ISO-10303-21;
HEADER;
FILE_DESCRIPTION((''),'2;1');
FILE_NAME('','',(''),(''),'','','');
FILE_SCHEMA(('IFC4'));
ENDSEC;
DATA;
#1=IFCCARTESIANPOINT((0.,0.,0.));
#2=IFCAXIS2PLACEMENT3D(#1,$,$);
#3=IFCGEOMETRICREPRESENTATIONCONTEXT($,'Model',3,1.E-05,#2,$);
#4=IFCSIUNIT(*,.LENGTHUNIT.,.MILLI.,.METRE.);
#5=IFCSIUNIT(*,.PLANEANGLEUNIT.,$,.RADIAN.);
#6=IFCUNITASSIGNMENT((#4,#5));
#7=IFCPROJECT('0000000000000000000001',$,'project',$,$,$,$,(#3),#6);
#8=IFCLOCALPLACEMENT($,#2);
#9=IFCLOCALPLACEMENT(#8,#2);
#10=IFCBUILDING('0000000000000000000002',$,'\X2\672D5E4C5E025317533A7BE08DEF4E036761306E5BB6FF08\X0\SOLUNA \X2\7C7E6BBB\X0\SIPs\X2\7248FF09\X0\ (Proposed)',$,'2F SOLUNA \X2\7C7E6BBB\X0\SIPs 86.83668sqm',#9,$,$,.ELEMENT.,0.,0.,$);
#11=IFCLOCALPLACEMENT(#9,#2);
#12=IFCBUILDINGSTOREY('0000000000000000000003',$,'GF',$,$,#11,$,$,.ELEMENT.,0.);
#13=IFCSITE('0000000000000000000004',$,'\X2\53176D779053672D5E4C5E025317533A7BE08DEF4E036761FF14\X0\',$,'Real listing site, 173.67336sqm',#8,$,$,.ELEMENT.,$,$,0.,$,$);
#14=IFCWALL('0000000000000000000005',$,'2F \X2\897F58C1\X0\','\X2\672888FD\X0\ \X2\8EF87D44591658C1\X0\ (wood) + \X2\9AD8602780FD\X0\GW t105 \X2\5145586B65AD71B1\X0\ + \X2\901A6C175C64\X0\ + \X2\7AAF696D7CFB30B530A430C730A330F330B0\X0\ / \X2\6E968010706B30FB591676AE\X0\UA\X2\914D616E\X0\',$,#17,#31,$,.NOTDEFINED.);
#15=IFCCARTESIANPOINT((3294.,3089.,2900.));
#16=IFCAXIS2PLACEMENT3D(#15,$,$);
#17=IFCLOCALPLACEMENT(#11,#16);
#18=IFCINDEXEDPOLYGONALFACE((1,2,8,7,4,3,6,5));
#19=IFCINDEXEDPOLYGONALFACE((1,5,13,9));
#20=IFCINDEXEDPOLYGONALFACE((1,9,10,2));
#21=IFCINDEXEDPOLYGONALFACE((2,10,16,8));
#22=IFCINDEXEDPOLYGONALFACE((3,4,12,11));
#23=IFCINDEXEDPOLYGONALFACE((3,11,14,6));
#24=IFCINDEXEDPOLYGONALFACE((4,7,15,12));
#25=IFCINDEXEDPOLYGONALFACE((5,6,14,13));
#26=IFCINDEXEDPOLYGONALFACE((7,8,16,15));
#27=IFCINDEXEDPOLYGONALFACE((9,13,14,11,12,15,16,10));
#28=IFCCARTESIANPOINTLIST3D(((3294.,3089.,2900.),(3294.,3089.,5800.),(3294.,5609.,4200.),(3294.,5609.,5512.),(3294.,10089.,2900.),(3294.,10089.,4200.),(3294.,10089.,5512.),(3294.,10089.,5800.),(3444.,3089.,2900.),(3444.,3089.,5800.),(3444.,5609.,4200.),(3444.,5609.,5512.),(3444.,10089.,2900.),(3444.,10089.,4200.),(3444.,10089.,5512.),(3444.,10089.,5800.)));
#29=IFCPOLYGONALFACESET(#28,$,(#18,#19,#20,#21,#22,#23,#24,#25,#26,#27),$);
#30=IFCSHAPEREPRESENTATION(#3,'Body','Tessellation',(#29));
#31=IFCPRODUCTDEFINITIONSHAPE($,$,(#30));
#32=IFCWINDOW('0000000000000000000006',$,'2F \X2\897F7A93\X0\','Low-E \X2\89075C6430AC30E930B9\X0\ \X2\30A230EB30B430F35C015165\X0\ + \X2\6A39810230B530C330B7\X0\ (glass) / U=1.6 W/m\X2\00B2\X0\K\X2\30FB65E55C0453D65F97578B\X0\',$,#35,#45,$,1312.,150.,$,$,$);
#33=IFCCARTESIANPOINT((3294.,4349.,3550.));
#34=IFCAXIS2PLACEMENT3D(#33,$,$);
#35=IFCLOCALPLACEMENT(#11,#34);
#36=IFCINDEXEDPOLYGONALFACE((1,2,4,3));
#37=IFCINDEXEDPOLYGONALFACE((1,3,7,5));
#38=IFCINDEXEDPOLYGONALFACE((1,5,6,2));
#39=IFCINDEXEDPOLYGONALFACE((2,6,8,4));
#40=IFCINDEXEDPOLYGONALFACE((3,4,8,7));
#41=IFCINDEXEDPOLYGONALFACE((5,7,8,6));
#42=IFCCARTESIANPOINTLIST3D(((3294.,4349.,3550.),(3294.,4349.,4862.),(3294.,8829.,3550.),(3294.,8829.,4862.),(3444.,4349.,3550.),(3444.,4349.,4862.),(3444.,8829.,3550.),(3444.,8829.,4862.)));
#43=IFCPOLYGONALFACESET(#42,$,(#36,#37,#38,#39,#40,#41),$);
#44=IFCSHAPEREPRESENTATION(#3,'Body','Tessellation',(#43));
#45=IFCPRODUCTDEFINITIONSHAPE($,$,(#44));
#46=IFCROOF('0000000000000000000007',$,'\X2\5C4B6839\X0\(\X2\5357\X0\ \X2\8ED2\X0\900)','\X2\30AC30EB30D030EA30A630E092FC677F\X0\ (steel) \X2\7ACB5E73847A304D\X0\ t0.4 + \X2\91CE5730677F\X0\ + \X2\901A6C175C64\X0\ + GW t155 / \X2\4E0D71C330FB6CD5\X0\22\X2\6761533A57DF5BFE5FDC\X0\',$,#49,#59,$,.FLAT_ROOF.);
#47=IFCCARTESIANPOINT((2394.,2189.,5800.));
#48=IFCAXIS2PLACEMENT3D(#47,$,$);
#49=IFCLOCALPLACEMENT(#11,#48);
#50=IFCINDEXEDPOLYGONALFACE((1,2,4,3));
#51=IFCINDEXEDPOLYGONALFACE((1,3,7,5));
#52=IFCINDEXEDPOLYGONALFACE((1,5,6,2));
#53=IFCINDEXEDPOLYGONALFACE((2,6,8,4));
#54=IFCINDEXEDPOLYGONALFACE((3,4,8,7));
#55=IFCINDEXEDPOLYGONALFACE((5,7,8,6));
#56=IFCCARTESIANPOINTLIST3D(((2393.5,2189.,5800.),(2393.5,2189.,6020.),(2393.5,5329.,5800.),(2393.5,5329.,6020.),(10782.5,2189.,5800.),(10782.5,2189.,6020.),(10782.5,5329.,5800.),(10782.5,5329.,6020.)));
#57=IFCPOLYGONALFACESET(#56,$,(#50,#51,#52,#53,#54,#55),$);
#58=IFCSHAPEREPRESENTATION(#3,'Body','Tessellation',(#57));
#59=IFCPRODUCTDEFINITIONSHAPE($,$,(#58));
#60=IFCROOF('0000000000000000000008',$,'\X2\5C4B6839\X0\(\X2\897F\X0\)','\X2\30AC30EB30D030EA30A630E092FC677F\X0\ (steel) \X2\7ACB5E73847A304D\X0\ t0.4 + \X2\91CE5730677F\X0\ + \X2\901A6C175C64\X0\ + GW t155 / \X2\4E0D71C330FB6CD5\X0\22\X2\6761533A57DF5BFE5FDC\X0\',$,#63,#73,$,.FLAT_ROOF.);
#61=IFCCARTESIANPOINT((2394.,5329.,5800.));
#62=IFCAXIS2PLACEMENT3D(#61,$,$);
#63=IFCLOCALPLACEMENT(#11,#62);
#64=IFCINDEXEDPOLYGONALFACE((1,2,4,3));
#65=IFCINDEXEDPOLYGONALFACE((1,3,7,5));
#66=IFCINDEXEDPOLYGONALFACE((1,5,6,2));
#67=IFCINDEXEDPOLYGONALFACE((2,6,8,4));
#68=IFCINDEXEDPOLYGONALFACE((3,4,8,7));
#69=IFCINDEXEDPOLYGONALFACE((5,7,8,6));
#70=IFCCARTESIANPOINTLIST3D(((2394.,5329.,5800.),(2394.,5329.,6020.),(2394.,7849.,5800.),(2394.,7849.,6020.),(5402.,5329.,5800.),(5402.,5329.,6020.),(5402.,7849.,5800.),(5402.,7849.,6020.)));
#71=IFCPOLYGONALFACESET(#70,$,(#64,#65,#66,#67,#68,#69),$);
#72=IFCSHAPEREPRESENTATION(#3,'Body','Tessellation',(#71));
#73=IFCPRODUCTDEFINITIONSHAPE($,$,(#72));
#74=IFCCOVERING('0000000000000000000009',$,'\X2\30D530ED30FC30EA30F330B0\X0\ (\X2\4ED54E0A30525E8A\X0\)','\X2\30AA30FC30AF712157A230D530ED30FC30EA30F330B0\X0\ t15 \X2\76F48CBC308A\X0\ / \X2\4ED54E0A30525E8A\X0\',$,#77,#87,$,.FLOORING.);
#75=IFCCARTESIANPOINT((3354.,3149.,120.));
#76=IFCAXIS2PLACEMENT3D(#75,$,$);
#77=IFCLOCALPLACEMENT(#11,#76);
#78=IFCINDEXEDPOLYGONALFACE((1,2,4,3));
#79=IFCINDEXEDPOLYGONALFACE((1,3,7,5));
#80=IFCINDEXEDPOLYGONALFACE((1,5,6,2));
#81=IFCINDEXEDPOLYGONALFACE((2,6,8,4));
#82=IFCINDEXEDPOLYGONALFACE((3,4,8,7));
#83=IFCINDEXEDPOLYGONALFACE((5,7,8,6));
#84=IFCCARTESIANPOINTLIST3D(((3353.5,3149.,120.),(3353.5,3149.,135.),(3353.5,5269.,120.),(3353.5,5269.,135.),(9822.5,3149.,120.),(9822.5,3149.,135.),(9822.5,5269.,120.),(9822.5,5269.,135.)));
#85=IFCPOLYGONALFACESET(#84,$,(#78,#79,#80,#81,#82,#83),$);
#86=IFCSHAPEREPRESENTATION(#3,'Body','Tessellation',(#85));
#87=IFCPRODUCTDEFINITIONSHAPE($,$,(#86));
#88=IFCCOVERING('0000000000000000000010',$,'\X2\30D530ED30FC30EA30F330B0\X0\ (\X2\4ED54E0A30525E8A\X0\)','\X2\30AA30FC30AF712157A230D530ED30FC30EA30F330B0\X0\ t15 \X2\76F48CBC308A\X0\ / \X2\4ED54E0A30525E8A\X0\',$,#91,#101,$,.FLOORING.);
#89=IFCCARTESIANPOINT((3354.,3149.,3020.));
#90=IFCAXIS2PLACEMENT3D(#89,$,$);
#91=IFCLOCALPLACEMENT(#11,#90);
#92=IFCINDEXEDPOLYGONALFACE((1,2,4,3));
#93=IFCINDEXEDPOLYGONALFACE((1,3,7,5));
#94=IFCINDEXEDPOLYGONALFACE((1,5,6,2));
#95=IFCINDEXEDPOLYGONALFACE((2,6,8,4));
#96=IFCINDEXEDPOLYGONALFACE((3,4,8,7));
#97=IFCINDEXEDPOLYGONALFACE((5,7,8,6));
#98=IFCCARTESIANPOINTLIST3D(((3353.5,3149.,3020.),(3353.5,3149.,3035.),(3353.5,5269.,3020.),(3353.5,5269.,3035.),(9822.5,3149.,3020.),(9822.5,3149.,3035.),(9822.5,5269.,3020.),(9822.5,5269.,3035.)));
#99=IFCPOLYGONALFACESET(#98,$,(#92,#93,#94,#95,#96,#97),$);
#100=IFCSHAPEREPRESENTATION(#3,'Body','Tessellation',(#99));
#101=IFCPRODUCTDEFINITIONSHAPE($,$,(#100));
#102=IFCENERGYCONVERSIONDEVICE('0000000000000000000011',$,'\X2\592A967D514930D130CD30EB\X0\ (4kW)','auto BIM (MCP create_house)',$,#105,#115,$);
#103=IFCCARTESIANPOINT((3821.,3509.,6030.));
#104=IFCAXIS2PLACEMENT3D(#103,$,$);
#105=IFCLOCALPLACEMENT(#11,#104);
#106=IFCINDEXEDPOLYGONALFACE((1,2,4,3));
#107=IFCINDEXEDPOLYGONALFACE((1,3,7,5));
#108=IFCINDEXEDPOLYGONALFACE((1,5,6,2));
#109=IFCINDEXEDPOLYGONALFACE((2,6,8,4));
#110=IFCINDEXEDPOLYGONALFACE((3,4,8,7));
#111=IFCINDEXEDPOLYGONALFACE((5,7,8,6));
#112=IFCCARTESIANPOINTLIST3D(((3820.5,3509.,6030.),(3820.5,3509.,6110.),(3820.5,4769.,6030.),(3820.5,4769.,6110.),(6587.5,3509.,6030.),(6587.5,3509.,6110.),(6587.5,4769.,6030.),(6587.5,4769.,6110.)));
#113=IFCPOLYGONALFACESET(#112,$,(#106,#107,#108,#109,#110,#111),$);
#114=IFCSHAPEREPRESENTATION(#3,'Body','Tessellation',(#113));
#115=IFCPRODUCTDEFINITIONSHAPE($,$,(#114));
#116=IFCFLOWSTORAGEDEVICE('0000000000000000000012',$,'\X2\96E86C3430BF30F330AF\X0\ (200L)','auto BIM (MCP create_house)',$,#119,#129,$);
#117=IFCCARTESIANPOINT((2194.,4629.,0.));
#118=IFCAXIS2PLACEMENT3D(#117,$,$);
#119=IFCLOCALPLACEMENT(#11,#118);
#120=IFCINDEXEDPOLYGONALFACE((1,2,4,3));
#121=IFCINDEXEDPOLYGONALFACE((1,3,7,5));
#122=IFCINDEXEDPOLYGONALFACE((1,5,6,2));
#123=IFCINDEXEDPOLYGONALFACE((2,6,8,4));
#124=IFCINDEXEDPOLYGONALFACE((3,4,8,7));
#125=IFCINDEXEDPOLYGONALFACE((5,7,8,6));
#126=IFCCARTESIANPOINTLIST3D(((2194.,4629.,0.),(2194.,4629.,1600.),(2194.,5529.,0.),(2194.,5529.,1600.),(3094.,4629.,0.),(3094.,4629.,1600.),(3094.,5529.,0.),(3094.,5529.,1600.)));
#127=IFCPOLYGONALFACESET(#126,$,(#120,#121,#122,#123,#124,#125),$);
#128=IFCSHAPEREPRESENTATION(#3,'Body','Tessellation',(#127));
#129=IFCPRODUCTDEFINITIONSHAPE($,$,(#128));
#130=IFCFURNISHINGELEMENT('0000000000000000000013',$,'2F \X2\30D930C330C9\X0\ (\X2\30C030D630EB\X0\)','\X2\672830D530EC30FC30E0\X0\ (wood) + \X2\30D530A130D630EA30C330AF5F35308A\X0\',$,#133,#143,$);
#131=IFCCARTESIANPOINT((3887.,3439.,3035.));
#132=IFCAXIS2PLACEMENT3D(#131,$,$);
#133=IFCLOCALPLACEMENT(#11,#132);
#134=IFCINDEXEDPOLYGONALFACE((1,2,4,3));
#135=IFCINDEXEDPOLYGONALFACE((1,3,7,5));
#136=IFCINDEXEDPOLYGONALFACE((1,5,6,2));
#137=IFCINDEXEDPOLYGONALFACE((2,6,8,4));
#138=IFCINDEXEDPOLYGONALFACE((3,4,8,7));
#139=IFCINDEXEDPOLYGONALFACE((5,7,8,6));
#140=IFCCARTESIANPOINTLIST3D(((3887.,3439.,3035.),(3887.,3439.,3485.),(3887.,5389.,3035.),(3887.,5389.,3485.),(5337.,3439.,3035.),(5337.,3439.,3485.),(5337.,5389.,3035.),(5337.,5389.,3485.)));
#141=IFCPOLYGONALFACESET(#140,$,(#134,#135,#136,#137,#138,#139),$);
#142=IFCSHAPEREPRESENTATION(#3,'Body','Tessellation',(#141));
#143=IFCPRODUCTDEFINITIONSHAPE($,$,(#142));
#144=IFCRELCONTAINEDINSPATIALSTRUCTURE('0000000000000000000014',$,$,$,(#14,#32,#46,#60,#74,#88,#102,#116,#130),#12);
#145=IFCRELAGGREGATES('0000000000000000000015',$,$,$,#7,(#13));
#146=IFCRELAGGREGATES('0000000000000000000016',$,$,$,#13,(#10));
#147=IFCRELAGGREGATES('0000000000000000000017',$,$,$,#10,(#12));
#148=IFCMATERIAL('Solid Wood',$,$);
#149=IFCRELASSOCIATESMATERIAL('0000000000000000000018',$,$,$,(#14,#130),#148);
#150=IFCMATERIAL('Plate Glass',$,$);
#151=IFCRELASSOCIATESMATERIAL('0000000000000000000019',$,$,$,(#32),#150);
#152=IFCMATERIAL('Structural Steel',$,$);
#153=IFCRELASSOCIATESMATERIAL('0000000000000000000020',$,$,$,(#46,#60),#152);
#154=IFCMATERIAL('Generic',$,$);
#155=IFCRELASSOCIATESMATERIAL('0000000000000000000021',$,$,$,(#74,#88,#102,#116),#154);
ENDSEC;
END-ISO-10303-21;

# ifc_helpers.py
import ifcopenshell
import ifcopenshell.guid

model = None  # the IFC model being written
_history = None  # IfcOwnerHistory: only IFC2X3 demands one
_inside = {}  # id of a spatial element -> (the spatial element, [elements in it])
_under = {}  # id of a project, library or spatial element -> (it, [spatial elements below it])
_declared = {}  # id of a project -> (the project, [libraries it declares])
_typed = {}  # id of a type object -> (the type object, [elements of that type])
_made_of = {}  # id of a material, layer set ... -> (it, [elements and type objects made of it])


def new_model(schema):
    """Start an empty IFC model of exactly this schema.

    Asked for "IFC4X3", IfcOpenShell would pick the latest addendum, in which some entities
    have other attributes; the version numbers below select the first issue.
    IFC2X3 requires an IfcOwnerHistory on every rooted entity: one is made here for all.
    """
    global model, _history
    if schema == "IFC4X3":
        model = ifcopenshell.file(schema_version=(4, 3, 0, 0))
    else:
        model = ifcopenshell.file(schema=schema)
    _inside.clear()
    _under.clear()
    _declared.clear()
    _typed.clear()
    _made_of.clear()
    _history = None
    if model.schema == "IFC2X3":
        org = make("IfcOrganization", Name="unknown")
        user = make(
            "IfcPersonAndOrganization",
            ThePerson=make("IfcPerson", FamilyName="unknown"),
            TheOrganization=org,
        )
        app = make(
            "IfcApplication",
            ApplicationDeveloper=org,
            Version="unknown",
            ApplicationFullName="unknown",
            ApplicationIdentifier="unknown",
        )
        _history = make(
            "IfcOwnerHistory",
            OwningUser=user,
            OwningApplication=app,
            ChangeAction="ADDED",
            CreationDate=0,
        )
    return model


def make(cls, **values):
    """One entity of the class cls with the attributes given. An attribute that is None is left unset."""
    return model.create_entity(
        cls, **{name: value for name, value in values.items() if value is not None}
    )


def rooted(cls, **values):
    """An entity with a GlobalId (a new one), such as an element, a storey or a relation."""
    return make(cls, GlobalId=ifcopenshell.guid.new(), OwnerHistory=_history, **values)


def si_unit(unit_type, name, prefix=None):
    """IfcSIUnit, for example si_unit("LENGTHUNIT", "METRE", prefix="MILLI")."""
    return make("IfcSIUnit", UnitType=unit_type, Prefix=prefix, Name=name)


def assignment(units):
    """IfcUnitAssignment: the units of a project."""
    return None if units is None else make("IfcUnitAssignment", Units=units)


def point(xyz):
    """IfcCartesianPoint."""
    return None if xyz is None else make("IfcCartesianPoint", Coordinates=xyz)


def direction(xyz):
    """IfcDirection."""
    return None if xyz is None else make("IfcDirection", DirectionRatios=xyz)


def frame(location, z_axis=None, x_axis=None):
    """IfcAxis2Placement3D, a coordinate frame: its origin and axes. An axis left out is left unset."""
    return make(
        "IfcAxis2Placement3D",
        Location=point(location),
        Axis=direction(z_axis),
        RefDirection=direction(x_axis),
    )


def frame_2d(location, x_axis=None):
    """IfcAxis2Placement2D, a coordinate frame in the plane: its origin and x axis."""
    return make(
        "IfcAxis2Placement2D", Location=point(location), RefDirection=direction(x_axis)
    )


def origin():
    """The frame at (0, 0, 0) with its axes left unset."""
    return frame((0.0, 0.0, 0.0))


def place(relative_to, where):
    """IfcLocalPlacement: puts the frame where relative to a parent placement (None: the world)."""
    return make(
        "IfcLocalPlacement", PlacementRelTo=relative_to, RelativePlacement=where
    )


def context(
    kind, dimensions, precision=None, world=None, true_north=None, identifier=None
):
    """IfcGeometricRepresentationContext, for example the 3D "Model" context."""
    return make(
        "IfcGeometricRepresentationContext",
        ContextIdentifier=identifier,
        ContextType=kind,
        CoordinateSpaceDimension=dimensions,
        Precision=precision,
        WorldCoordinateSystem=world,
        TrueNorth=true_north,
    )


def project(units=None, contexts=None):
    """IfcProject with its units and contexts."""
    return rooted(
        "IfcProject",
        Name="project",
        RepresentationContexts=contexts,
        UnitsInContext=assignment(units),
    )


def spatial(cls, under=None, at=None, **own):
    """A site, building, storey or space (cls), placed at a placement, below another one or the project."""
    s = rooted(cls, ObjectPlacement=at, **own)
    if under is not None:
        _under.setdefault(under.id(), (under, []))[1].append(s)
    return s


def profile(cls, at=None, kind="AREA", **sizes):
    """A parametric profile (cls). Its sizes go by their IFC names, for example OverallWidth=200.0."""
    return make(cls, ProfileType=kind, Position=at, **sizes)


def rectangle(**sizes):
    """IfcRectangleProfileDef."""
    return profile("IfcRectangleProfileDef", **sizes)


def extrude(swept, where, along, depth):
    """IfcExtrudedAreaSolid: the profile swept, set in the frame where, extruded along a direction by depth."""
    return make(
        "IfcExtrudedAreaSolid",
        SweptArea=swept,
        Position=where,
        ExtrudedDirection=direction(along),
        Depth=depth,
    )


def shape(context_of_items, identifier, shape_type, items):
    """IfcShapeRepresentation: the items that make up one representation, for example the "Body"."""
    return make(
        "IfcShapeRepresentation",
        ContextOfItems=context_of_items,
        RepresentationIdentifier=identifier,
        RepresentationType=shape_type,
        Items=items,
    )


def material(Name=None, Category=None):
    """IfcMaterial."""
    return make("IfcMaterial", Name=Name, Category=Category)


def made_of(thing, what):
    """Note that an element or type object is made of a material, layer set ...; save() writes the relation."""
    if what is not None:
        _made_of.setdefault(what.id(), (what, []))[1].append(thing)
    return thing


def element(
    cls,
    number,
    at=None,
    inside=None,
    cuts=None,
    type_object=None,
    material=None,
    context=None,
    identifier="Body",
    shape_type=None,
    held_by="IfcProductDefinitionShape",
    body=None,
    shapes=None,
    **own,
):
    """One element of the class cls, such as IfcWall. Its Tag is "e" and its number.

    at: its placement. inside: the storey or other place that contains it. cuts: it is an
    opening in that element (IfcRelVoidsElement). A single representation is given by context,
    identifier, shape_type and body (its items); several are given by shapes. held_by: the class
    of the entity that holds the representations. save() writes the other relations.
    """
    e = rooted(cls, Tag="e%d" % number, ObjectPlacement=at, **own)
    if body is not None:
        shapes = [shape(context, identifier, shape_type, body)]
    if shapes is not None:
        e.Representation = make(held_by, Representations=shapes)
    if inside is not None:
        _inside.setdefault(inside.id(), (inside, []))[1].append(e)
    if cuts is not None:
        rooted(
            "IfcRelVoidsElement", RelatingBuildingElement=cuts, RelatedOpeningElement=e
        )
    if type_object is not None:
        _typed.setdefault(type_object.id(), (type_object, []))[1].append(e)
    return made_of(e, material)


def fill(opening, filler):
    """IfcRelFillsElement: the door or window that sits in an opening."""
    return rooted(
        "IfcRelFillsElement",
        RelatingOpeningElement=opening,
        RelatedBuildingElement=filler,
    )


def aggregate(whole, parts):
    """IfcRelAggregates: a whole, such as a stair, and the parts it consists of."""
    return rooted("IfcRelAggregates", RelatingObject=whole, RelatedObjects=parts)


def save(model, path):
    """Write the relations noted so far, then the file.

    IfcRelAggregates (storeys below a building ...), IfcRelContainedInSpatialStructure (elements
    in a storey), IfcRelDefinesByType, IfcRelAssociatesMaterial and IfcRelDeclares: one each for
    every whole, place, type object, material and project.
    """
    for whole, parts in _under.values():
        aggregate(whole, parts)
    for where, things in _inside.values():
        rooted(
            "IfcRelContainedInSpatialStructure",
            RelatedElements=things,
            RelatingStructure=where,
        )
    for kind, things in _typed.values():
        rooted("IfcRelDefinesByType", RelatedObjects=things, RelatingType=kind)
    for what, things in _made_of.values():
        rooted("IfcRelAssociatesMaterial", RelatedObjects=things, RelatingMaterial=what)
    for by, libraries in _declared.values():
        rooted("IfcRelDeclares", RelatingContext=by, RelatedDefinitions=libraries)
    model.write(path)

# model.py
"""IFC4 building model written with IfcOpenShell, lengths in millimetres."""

from ifc_helpers import new_model, si_unit, frame, frame_2d, origin, place, context, project, spatial, rectangle, extrude, material, element, fill, save


model = new_model("IFC4")

# Units and contexts
model_context = context("Model", 3, precision=1e-05, world=origin())
ifc_project = project(units=[si_unit("LENGTHUNIT", "METRE", prefix="MILLI"), si_unit("PLANEANGLEUNIT", "RADIAN")], contexts=[model_context])

# Site, building, storey
site_placement = place(None, origin())
site = spatial("IfcSite", under=ifc_project, at=site_placement, Name="北海道札幌市北区篠路七条４", ObjectType="Real listing site, 173.67336sqm", CompositionType="ELEMENT", RefElevation=0.0)
building_placement = place(site_placement, origin())
building = spatial("IfcBuilding", under=site, at=building_placement, Name="札幌市北区篠路七条の家（SOLUNA 籾殻SIPs版） (Proposed)", ObjectType="2F SOLUNA 籾殻SIPs 86.83668sqm", CompositionType="ELEMENT", ElevationOfRefHeight=0.0, ElevationOfTerrain=0.0)
storey_placement = place(building_placement, origin())
storey = spatial("IfcBuildingStorey", under=building, at=storey_placement, Name="GF", CompositionType="ELEMENT", Elevation=0.0)

# Shared definitions
ifc_material_1 = material(Name="Solid Wood")

# Shared definitions
ifc_material_2 = material(Name="Plate Glass")

# Wall, opening, window
wall_1_placement = place(storey_placement, frame((3294.0, 3089.0, 2900.0)))
wall_1 = element("IfcWall", 1, at=wall_1_placement, inside=storey, material=ifc_material_1, Name="2F 西壁", Description="木製 軸組外壁 (wood) + 高性能GW t105 充填断熱 + 通気層 + 窯業系サイディング / 準耐火・外皮UA配慮", PredefinedType="NOTDEFINED", context=model_context, shape_type="SweptSolid", body=[
    extrude(rectangle(XDim=150.0, YDim=7000.0, at=frame_2d((75.0, 3500.0))), frame((3294.0, 3089.0, 2900.0)), (0.0, 0.0, 1.0), 2900.0),
])
opening_1_placement = place(storey_placement, frame((3294.0, 4349.0, 3550.0)))
opening_1 = element("IfcOpeningElement", 2, at=opening_1_placement, cuts=wall_1, PredefinedType="NOTDEFINED", context=model_context, shape_type="SweptSolid", body=[
    extrude(rectangle(XDim=150.0, YDim=4480.0, at=frame_2d((75.0, 2240.0))), frame((3294.0, 4349.0, 3550.0)), (0.0, 0.0, 1.0), 1312.0),
])
window_1_placement = place(storey_placement, frame((3294.0, 4349.0, 3550.0)))
window_1 = element("IfcWindow", 3, at=window_1_placement, inside=storey, material=ifc_material_2, Name="2F 西窓", Description="Low-E 複層ガラス アルゴン封入 + 樹脂サッシ (glass) / U=1.6 W/m²K・日射取得型", OverallHeight=1312.0, OverallWidth=150.0, context=model_context, shape_type="SweptSolid", body=[
    extrude(rectangle(XDim=150.0, YDim=4480.0, at=frame_2d((75.0, 2240.0))), frame((3294.0, 4349.0, 3550.0)), (0.0, 0.0, 1.0), 1312.0),
])
fill(opening_1, window_1)

# Roofs
ifc_material_3 = material(Name="Structural Steel")
roof_1_placement = place(storey_placement, frame((2394.0, 2189.0, 5800.0)))
element("IfcRoof", 4, at=roof_1_placement, inside=storey, material=ifc_material_3, Name="屋根(南 軒900)", Description="ガルバリウム鋼板 (steel) 立平葺き t0.4 + 野地板 + 通気層 + GW t155 / 不燃・法22条区域対応", PredefinedType="FLAT_ROOF", context=model_context, shape_type="SweptSolid", body=[
    extrude(rectangle(XDim=8389.0, YDim=3140.0, at=frame_2d((4194.0, 1570.0))), frame((2394.0, 2189.0, 5800.0)), (0.0, 0.0, 1.0), 220.0),
])
roof_2_placement = place(storey_placement, frame((2394.0, 5329.0, 5800.0)))
element("IfcRoof", 5, at=roof_2_placement, inside=storey, material=ifc_material_3, Name="屋根(西)", Description="ガルバリウム鋼板 (steel) 立平葺き t0.4 + 野地板 + 通気層 + GW t155 / 不燃・法22条区域対応", PredefinedType="FLAT_ROOF", context=model_context, shape_type="SweptSolid", body=[
    extrude(rectangle(XDim=3008.0, YDim=2520.0, at=frame_2d((1504.0, 1260.0))), frame((2394.0, 5329.0, 5800.0)), (0.0, 0.0, 1.0), 220.0),
])

# Coverings
ifc_material_4 = material(Name="Generic")
covering_1_placement = place(storey_placement, frame((3354.0, 3149.0, 120.0)))
element("IfcCovering", 6, at=covering_1_placement, inside=storey, material=ifc_material_4, Name="フローリング (仕上げ床)", Description="オーク無垢フローリング t15 直貼り / 仕上げ床", PredefinedType="FLOORING", context=model_context, shape_type="SweptSolid", body=[
    extrude(rectangle(XDim=6469.0, YDim=2120.0, at=frame_2d((3234.0, 1060.0))), frame((3354.0, 3149.0, 120.0)), (0.0, 0.0, 1.0), 15.0),
])
covering_2_placement = place(storey_placement, frame((3354.0, 3149.0, 3020.0)))
element("IfcCovering", 7, at=covering_2_placement, inside=storey, material=ifc_material_4, Name="フローリング (仕上げ床)", Description="オーク無垢フローリング t15 直貼り / 仕上げ床", PredefinedType="FLOORING", context=model_context, shape_type="SweptSolid", body=[
    extrude(rectangle(XDim=6469.0, YDim=2120.0, at=frame_2d((3234.0, 1060.0))), frame((3354.0, 3149.0, 3020.0)), (0.0, 0.0, 1.0), 15.0),
])

# Energy conversion device
energy_conversion_device_placement = place(storey_placement, frame((3821.0, 3509.0, 6030.0)))
element("IfcEnergyConversionDevice", 8, at=energy_conversion_device_placement, inside=storey, material=ifc_material_4, Name="太陽光パネル (4kW)", Description="auto BIM (MCP create_house)", context=model_context, shape_type="SweptSolid", body=[
    extrude(rectangle(XDim=2767.0, YDim=1260.0, at=frame_2d((1383.0, 630.0))), frame((3821.0, 3509.0, 6030.0)), (0.0, 0.0, 1.0), 80.0),
])

# Flow storage device
flow_storage_device_placement = place(storey_placement, frame((2194.0, 4629.0, 0.0)))
element("IfcFlowStorageDevice", 9, at=flow_storage_device_placement, inside=storey, material=ifc_material_4, Name="雨水タンク (200L)", Description="auto BIM (MCP create_house)", context=model_context, shape_type="SweptSolid", body=[
    extrude(rectangle(XDim=900.0, YDim=900.0, at=frame_2d((450.0, 450.0))), frame((2194.0, 4629.0, 0.0)), (0.0, 0.0, 1.0), 1600.0),
])

# Furnishing element
furnishing_placement = place(storey_placement, frame((3887.0, 3439.0, 3035.0)))
element("IfcFurnishingElement", 10, at=furnishing_placement, inside=storey, material=ifc_material_1, Name="2F ベッド (ダブル)", Description="木フレーム (wood) + ファブリック張り", context=model_context, shape_type="SweptSolid", body=[
    extrude(rectangle(XDim=1450.0, YDim=1950.0, at=frame_2d((725.0, 975.0))), frame((3887.0, 3439.0, 3035.0)), (0.0, 0.0, 1.0), 450.0),
])

save(model, "model.ifc")
